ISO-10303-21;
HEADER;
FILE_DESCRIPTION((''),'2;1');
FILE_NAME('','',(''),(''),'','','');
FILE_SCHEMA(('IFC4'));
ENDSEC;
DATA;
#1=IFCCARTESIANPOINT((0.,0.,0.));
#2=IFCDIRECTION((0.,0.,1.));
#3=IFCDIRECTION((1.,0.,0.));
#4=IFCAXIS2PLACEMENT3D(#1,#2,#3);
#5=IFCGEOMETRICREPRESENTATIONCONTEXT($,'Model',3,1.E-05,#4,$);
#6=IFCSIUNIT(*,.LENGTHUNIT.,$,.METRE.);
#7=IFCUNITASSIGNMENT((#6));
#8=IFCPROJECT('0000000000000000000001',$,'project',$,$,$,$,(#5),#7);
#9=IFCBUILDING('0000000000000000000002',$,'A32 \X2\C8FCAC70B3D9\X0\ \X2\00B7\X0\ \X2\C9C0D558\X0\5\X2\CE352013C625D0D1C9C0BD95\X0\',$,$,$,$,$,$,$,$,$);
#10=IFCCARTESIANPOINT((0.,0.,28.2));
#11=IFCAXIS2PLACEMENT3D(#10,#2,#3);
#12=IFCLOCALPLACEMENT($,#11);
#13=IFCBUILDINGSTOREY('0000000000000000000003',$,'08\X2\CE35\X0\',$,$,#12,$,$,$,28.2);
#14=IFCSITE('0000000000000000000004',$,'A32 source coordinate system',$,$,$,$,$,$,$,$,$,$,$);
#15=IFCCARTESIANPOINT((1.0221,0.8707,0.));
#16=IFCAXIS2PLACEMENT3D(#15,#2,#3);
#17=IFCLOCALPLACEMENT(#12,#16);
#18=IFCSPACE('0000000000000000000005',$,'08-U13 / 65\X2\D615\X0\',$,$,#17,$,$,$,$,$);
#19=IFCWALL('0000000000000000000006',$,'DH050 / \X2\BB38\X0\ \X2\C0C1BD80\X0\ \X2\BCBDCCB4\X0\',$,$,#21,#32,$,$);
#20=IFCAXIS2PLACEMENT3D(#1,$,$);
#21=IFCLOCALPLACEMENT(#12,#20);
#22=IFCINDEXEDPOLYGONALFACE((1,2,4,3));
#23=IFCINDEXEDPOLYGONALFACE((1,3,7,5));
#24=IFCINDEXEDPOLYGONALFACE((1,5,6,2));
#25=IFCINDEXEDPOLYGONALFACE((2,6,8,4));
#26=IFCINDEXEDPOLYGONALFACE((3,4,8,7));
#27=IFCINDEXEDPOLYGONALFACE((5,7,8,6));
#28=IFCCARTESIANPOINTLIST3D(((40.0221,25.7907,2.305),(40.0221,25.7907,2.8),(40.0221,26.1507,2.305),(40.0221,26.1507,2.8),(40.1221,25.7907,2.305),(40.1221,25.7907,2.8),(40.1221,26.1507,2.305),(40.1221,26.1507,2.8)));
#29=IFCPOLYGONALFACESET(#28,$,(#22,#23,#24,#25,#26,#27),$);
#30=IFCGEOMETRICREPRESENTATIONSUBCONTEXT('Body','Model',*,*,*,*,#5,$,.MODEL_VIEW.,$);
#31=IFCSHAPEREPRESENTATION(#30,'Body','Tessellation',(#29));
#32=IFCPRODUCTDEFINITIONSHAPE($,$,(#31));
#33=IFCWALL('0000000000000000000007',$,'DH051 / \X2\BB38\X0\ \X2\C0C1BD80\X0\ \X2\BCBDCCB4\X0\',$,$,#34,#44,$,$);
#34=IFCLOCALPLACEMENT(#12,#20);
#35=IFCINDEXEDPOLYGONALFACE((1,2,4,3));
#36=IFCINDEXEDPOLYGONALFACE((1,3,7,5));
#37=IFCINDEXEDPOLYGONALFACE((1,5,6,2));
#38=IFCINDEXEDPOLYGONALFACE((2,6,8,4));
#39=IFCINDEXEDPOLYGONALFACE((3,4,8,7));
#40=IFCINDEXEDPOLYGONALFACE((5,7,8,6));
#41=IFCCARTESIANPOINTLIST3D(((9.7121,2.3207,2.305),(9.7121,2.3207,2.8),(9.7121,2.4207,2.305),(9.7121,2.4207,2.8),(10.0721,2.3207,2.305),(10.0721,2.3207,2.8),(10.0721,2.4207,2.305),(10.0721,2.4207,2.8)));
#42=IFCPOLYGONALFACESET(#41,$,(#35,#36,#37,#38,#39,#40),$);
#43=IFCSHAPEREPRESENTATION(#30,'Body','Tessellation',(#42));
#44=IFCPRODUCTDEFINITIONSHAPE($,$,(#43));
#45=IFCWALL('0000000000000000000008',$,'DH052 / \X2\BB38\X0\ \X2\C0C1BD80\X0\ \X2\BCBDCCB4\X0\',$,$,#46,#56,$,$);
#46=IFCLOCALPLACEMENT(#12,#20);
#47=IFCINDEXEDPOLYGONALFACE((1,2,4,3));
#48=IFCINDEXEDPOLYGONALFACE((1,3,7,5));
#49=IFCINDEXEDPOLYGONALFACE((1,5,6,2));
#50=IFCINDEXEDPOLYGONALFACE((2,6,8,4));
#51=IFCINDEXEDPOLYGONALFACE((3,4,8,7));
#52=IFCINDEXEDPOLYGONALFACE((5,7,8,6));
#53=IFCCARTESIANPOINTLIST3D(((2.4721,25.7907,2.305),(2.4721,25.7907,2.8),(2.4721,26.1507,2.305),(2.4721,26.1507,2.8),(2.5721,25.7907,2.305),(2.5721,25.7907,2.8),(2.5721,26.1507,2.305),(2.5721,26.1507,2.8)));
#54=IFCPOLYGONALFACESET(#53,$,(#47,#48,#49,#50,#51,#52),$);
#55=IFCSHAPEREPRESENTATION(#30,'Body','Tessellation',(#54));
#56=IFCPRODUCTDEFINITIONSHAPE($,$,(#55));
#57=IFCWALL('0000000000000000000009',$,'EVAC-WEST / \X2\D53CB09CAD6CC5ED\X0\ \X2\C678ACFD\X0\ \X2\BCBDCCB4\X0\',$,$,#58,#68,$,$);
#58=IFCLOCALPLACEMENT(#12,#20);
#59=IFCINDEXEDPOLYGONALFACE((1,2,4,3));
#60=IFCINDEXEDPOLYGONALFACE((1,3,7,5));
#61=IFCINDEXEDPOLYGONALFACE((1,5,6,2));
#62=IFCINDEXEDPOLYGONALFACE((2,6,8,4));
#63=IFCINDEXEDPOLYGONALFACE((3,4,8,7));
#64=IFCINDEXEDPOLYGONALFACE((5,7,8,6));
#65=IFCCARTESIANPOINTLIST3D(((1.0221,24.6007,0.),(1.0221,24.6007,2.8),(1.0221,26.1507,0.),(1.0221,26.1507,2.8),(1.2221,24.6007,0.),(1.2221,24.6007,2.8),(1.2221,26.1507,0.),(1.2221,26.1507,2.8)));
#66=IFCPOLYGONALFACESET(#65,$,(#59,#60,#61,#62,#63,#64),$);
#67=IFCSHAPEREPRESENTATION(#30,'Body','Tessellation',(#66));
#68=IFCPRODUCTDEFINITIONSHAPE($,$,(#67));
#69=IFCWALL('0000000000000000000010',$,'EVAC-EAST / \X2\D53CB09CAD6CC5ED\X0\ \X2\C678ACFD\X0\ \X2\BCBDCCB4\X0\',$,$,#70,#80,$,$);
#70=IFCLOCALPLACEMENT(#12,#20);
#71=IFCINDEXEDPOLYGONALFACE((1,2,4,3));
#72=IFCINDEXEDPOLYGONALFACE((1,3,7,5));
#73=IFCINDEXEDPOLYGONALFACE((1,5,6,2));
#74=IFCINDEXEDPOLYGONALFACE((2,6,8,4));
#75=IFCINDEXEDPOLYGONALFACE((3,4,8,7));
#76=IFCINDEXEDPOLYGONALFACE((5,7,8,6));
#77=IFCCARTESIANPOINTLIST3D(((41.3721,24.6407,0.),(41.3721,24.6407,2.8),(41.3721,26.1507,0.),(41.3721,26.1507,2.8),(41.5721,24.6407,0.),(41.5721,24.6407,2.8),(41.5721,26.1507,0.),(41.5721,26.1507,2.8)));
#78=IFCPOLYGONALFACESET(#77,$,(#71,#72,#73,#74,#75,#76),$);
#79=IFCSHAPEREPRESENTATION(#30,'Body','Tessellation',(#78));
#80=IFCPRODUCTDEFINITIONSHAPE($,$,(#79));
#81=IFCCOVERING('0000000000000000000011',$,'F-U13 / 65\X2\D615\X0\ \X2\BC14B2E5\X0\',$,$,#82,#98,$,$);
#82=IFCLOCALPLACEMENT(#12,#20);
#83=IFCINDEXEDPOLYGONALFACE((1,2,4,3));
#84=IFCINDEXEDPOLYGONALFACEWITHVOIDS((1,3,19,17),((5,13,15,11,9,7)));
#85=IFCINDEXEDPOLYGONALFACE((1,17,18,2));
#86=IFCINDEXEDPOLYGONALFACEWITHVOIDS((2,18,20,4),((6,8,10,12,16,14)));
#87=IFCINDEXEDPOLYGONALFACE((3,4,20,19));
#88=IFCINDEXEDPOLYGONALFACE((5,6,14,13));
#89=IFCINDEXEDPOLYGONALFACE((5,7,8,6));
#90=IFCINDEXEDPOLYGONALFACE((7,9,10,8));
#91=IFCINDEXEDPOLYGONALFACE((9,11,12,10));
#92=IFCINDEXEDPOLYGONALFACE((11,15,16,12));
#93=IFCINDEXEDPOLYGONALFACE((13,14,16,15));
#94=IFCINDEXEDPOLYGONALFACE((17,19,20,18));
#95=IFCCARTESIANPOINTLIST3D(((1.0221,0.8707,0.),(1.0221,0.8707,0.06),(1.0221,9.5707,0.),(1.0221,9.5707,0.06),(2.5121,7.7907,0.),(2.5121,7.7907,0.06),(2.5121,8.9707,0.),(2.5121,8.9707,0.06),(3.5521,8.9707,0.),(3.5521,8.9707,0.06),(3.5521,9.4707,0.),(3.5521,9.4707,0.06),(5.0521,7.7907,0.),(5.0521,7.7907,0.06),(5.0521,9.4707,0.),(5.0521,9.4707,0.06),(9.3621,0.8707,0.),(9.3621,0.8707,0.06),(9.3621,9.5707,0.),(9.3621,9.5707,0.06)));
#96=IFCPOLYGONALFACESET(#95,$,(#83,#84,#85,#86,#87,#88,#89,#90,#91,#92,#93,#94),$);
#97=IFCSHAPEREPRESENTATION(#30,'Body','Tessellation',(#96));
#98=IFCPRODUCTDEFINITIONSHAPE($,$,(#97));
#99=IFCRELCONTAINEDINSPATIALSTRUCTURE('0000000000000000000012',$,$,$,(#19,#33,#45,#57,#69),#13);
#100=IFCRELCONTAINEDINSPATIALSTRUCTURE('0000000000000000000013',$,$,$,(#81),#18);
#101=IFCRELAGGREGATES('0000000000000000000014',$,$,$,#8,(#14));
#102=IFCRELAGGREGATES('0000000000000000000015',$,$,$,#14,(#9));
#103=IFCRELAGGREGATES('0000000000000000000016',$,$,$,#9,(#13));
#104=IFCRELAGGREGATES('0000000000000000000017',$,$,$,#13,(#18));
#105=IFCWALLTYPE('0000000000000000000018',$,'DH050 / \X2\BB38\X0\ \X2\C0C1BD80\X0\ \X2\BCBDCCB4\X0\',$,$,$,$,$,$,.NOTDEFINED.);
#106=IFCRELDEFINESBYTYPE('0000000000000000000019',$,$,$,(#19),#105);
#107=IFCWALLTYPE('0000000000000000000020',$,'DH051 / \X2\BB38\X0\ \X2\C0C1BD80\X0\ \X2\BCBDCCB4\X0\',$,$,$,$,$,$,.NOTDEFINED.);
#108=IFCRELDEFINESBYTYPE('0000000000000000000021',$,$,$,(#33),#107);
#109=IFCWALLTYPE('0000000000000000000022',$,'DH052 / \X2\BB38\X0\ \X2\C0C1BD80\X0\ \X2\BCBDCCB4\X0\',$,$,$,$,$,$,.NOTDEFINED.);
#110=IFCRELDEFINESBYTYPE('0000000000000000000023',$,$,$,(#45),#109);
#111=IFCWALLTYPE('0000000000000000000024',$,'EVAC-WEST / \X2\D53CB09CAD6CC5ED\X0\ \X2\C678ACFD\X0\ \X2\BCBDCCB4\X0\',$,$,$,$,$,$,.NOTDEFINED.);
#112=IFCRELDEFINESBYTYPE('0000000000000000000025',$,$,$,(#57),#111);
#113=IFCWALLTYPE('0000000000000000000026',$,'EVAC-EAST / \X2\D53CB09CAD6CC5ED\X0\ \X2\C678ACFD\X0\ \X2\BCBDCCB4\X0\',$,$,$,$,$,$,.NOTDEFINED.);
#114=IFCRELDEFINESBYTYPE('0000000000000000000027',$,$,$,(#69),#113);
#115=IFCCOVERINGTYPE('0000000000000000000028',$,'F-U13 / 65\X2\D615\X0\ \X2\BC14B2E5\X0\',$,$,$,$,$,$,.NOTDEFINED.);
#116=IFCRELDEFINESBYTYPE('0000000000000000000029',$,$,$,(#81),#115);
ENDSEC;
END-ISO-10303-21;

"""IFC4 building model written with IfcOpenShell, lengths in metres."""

from ifc_helpers import new_model, si_unit, frame, origin, origin_with_axes, place, context, subcontext, project, spatial, polyline, outline, extrude, source, transform, mapped, type_object, type_shapes, element, save


model = new_model("IFC4")

# Units and contexts
model_context = context("Model", 3, precision=1e-05, world=origin_with_axes())
body_context = subcontext(model_context, "Body", "Model", "MODEL_VIEW")
ifc_project = project(units=[si_unit("LENGTHUNIT", "METRE")], contexts=[model_context])

# Site, building, storey
site = spatial("IfcSite", under=ifc_project, Name="A32 source coordinate system")
building = spatial("IfcBuilding", under=site, Name="A32 주거동 · 지하5층–옥탑지붕")
storey_placement = place(None, frame((0.0, 0.0, 28.2), z_axis=(0.0, 0.0, 1.0), x_axis=(1.0, 0.0, 0.0)))
storey = spatial("IfcBuildingStorey", under=building, at=storey_placement, Name="08층", Elevation=28.2)

# Walls
wall_type_1 = type_object("IfcWallType", Name="DH050 / 문 상부 벽체", PredefinedType="NOTDEFINED")
shared_shape_1 = source(origin(), body_context, "Body", "SweptSolid", [
    extrude(outline(polyline([(40.0221, 25.7907), (40.0221, 26.1507), (40.1221, 26.1507), (40.1221, 25.7907), (40.0221, 25.7907)])), frame((0.0, 0.0, 2.305)), (0.0, 0.0, 1.0), 0.495),
])
type_shapes(wall_type_1, [shared_shape_1])
wall_1_placement = place(storey_placement, origin_with_axes())
element("IfcWall", 1, at=wall_1_placement, inside=storey, type_object=wall_type_1, Name="DH050 / 문 상부 벽체", context=body_context, shape_type="MappedRepresentation", body=[
    mapped(shared_shape_1, transform((0.0, 0.0, 0.0), scale=1.0)),
])
wall_type_2 = type_object("IfcWallType", Name="DH051 / 문 상부 벽체", PredefinedType="NOTDEFINED")
shared_shape_2 = source(origin(), body_context, "Body", "SweptSolid", [
    extrude(outline(polyline([(10.0721, 2.3207), (9.7121, 2.3207), (9.7121, 2.4207), (10.0721, 2.4207), (10.0721, 2.3207)])), frame((0.0, 0.0, 2.305)), (0.0, 0.0, 1.0), 0.495),
])
type_shapes(wall_type_2, [shared_shape_2])
wall_2_placement = place(storey_placement, origin_with_axes())
element("IfcWall", 2, at=wall_2_placement, inside=storey, type_object=wall_type_2, Name="DH051 / 문 상부 벽체", context=body_context, shape_type="MappedRepresentation", body=[
    mapped(shared_shape_2, transform((0.0, 0.0, 0.0), scale=1.0)),
])
wall_type_3 = type_object("IfcWallType", Name="DH052 / 문 상부 벽체", PredefinedType="NOTDEFINED")
shared_shape_3 = source(origin(), body_context, "Body", "SweptSolid", [
    extrude(outline(polyline([(2.5721, 25.7907), (2.4721, 25.7907), (2.4721, 26.1507), (2.5721, 26.1507), (2.5721, 25.7907)])), frame((0.0, 0.0, 2.305)), (0.0, 0.0, 1.0), 0.495),
])
type_shapes(wall_type_3, [shared_shape_3])
wall_3_placement = place(storey_placement, origin_with_axes())
element("IfcWall", 3, at=wall_3_placement, inside=storey, type_object=wall_type_3, Name="DH052 / 문 상부 벽체", context=body_context, shape_type="MappedRepresentation", body=[
    mapped(shared_shape_3, transform((0.0, 0.0, 0.0), scale=1.0)),
])
wall_type_4 = type_object("IfcWallType", Name="EVAC-WEST / 피난구역 외곽 벽체", PredefinedType="NOTDEFINED")
shared_shape_4 = source(origin(), body_context, "Body", "SweptSolid", [
    extrude(outline(polyline([(1.2221, 24.6007), (1.0221, 24.6007), (1.0221, 26.1507), (1.2221, 26.1507), (1.2221, 24.6007)])), origin(), (0.0, 0.0, 1.0), 2.8),
])
type_shapes(wall_type_4, [shared_shape_4])
wall_4_placement = place(storey_placement, origin_with_axes())
element("IfcWall", 4, at=wall_4_placement, inside=storey, type_object=wall_type_4, Name="EVAC-WEST / 피난구역 외곽 벽체", context=body_context, shape_type="MappedRepresentation", body=[
    mapped(shared_shape_4, transform((0.0, 0.0, 0.0), scale=1.0)),
])
wall_type_5 = type_object("IfcWallType", Name="EVAC-EAST / 피난구역 외곽 벽체", PredefinedType="NOTDEFINED")
shared_shape_5 = source(origin(), body_context, "Body", "SweptSolid", [
    extrude(outline(polyline([(41.5721, 26.1507), (41.5721, 24.6407), (41.3721, 24.6407), (41.3721, 26.1507), (41.5721, 26.1507)])), origin(), (0.0, 0.0, 1.0), 2.8),
])
type_shapes(wall_type_5, [shared_shape_5])
wall_5_placement = place(storey_placement, origin_with_axes())
element("IfcWall", 5, at=wall_5_placement, inside=storey, type_object=wall_type_5, Name="EVAC-EAST / 피난구역 외곽 벽체", context=body_context, shape_type="MappedRepresentation", body=[
    mapped(shared_shape_5, transform((0.0, 0.0, 0.0), scale=1.0)),
])

# Shared definitions
space_placement = place(storey_placement, frame((1.0221, 0.8707, 0.0), z_axis=(0.0, 0.0, 1.0), x_axis=(1.0, 0.0, 0.0)))
space = spatial("IfcSpace", under=storey, at=space_placement, Name="08-U13 / 65형")

# Covering
covering_type_1 = type_object("IfcCoveringType", Name="F-U13 / 65형 바닥", PredefinedType="NOTDEFINED")
shared_shape_6 = source(origin(), body_context, "Body", "SweptSolid", [
    extrude(outline(polyline([(0.0, 0.0), (0.0, 8.7), (8.34, 8.7), (8.34, 0.0), (0.0, 0.0)]), holes=[polyline([(2.53, 8.1), (1.49, 8.1), (1.49, 6.92), (4.03, 6.92), (4.03, 8.6), (2.53, 8.6), (2.53, 8.1)])]), origin(), (0.0, 0.0, 1.0), 0.06),
])
type_shapes(covering_type_1, [shared_shape_6])
covering_1_placement = place(space_placement, origin_with_axes())
element("IfcCovering", 6, at=covering_1_placement, inside=space, type_object=covering_type_1, Name="F-U13 / 65형 바닥", context=body_context, shape_type="MappedRepresentation", body=[
    mapped(shared_shape_6, transform((0.0, 0.0, 0.0), scale=1.0)),
])

save(model, "model.ifc")
